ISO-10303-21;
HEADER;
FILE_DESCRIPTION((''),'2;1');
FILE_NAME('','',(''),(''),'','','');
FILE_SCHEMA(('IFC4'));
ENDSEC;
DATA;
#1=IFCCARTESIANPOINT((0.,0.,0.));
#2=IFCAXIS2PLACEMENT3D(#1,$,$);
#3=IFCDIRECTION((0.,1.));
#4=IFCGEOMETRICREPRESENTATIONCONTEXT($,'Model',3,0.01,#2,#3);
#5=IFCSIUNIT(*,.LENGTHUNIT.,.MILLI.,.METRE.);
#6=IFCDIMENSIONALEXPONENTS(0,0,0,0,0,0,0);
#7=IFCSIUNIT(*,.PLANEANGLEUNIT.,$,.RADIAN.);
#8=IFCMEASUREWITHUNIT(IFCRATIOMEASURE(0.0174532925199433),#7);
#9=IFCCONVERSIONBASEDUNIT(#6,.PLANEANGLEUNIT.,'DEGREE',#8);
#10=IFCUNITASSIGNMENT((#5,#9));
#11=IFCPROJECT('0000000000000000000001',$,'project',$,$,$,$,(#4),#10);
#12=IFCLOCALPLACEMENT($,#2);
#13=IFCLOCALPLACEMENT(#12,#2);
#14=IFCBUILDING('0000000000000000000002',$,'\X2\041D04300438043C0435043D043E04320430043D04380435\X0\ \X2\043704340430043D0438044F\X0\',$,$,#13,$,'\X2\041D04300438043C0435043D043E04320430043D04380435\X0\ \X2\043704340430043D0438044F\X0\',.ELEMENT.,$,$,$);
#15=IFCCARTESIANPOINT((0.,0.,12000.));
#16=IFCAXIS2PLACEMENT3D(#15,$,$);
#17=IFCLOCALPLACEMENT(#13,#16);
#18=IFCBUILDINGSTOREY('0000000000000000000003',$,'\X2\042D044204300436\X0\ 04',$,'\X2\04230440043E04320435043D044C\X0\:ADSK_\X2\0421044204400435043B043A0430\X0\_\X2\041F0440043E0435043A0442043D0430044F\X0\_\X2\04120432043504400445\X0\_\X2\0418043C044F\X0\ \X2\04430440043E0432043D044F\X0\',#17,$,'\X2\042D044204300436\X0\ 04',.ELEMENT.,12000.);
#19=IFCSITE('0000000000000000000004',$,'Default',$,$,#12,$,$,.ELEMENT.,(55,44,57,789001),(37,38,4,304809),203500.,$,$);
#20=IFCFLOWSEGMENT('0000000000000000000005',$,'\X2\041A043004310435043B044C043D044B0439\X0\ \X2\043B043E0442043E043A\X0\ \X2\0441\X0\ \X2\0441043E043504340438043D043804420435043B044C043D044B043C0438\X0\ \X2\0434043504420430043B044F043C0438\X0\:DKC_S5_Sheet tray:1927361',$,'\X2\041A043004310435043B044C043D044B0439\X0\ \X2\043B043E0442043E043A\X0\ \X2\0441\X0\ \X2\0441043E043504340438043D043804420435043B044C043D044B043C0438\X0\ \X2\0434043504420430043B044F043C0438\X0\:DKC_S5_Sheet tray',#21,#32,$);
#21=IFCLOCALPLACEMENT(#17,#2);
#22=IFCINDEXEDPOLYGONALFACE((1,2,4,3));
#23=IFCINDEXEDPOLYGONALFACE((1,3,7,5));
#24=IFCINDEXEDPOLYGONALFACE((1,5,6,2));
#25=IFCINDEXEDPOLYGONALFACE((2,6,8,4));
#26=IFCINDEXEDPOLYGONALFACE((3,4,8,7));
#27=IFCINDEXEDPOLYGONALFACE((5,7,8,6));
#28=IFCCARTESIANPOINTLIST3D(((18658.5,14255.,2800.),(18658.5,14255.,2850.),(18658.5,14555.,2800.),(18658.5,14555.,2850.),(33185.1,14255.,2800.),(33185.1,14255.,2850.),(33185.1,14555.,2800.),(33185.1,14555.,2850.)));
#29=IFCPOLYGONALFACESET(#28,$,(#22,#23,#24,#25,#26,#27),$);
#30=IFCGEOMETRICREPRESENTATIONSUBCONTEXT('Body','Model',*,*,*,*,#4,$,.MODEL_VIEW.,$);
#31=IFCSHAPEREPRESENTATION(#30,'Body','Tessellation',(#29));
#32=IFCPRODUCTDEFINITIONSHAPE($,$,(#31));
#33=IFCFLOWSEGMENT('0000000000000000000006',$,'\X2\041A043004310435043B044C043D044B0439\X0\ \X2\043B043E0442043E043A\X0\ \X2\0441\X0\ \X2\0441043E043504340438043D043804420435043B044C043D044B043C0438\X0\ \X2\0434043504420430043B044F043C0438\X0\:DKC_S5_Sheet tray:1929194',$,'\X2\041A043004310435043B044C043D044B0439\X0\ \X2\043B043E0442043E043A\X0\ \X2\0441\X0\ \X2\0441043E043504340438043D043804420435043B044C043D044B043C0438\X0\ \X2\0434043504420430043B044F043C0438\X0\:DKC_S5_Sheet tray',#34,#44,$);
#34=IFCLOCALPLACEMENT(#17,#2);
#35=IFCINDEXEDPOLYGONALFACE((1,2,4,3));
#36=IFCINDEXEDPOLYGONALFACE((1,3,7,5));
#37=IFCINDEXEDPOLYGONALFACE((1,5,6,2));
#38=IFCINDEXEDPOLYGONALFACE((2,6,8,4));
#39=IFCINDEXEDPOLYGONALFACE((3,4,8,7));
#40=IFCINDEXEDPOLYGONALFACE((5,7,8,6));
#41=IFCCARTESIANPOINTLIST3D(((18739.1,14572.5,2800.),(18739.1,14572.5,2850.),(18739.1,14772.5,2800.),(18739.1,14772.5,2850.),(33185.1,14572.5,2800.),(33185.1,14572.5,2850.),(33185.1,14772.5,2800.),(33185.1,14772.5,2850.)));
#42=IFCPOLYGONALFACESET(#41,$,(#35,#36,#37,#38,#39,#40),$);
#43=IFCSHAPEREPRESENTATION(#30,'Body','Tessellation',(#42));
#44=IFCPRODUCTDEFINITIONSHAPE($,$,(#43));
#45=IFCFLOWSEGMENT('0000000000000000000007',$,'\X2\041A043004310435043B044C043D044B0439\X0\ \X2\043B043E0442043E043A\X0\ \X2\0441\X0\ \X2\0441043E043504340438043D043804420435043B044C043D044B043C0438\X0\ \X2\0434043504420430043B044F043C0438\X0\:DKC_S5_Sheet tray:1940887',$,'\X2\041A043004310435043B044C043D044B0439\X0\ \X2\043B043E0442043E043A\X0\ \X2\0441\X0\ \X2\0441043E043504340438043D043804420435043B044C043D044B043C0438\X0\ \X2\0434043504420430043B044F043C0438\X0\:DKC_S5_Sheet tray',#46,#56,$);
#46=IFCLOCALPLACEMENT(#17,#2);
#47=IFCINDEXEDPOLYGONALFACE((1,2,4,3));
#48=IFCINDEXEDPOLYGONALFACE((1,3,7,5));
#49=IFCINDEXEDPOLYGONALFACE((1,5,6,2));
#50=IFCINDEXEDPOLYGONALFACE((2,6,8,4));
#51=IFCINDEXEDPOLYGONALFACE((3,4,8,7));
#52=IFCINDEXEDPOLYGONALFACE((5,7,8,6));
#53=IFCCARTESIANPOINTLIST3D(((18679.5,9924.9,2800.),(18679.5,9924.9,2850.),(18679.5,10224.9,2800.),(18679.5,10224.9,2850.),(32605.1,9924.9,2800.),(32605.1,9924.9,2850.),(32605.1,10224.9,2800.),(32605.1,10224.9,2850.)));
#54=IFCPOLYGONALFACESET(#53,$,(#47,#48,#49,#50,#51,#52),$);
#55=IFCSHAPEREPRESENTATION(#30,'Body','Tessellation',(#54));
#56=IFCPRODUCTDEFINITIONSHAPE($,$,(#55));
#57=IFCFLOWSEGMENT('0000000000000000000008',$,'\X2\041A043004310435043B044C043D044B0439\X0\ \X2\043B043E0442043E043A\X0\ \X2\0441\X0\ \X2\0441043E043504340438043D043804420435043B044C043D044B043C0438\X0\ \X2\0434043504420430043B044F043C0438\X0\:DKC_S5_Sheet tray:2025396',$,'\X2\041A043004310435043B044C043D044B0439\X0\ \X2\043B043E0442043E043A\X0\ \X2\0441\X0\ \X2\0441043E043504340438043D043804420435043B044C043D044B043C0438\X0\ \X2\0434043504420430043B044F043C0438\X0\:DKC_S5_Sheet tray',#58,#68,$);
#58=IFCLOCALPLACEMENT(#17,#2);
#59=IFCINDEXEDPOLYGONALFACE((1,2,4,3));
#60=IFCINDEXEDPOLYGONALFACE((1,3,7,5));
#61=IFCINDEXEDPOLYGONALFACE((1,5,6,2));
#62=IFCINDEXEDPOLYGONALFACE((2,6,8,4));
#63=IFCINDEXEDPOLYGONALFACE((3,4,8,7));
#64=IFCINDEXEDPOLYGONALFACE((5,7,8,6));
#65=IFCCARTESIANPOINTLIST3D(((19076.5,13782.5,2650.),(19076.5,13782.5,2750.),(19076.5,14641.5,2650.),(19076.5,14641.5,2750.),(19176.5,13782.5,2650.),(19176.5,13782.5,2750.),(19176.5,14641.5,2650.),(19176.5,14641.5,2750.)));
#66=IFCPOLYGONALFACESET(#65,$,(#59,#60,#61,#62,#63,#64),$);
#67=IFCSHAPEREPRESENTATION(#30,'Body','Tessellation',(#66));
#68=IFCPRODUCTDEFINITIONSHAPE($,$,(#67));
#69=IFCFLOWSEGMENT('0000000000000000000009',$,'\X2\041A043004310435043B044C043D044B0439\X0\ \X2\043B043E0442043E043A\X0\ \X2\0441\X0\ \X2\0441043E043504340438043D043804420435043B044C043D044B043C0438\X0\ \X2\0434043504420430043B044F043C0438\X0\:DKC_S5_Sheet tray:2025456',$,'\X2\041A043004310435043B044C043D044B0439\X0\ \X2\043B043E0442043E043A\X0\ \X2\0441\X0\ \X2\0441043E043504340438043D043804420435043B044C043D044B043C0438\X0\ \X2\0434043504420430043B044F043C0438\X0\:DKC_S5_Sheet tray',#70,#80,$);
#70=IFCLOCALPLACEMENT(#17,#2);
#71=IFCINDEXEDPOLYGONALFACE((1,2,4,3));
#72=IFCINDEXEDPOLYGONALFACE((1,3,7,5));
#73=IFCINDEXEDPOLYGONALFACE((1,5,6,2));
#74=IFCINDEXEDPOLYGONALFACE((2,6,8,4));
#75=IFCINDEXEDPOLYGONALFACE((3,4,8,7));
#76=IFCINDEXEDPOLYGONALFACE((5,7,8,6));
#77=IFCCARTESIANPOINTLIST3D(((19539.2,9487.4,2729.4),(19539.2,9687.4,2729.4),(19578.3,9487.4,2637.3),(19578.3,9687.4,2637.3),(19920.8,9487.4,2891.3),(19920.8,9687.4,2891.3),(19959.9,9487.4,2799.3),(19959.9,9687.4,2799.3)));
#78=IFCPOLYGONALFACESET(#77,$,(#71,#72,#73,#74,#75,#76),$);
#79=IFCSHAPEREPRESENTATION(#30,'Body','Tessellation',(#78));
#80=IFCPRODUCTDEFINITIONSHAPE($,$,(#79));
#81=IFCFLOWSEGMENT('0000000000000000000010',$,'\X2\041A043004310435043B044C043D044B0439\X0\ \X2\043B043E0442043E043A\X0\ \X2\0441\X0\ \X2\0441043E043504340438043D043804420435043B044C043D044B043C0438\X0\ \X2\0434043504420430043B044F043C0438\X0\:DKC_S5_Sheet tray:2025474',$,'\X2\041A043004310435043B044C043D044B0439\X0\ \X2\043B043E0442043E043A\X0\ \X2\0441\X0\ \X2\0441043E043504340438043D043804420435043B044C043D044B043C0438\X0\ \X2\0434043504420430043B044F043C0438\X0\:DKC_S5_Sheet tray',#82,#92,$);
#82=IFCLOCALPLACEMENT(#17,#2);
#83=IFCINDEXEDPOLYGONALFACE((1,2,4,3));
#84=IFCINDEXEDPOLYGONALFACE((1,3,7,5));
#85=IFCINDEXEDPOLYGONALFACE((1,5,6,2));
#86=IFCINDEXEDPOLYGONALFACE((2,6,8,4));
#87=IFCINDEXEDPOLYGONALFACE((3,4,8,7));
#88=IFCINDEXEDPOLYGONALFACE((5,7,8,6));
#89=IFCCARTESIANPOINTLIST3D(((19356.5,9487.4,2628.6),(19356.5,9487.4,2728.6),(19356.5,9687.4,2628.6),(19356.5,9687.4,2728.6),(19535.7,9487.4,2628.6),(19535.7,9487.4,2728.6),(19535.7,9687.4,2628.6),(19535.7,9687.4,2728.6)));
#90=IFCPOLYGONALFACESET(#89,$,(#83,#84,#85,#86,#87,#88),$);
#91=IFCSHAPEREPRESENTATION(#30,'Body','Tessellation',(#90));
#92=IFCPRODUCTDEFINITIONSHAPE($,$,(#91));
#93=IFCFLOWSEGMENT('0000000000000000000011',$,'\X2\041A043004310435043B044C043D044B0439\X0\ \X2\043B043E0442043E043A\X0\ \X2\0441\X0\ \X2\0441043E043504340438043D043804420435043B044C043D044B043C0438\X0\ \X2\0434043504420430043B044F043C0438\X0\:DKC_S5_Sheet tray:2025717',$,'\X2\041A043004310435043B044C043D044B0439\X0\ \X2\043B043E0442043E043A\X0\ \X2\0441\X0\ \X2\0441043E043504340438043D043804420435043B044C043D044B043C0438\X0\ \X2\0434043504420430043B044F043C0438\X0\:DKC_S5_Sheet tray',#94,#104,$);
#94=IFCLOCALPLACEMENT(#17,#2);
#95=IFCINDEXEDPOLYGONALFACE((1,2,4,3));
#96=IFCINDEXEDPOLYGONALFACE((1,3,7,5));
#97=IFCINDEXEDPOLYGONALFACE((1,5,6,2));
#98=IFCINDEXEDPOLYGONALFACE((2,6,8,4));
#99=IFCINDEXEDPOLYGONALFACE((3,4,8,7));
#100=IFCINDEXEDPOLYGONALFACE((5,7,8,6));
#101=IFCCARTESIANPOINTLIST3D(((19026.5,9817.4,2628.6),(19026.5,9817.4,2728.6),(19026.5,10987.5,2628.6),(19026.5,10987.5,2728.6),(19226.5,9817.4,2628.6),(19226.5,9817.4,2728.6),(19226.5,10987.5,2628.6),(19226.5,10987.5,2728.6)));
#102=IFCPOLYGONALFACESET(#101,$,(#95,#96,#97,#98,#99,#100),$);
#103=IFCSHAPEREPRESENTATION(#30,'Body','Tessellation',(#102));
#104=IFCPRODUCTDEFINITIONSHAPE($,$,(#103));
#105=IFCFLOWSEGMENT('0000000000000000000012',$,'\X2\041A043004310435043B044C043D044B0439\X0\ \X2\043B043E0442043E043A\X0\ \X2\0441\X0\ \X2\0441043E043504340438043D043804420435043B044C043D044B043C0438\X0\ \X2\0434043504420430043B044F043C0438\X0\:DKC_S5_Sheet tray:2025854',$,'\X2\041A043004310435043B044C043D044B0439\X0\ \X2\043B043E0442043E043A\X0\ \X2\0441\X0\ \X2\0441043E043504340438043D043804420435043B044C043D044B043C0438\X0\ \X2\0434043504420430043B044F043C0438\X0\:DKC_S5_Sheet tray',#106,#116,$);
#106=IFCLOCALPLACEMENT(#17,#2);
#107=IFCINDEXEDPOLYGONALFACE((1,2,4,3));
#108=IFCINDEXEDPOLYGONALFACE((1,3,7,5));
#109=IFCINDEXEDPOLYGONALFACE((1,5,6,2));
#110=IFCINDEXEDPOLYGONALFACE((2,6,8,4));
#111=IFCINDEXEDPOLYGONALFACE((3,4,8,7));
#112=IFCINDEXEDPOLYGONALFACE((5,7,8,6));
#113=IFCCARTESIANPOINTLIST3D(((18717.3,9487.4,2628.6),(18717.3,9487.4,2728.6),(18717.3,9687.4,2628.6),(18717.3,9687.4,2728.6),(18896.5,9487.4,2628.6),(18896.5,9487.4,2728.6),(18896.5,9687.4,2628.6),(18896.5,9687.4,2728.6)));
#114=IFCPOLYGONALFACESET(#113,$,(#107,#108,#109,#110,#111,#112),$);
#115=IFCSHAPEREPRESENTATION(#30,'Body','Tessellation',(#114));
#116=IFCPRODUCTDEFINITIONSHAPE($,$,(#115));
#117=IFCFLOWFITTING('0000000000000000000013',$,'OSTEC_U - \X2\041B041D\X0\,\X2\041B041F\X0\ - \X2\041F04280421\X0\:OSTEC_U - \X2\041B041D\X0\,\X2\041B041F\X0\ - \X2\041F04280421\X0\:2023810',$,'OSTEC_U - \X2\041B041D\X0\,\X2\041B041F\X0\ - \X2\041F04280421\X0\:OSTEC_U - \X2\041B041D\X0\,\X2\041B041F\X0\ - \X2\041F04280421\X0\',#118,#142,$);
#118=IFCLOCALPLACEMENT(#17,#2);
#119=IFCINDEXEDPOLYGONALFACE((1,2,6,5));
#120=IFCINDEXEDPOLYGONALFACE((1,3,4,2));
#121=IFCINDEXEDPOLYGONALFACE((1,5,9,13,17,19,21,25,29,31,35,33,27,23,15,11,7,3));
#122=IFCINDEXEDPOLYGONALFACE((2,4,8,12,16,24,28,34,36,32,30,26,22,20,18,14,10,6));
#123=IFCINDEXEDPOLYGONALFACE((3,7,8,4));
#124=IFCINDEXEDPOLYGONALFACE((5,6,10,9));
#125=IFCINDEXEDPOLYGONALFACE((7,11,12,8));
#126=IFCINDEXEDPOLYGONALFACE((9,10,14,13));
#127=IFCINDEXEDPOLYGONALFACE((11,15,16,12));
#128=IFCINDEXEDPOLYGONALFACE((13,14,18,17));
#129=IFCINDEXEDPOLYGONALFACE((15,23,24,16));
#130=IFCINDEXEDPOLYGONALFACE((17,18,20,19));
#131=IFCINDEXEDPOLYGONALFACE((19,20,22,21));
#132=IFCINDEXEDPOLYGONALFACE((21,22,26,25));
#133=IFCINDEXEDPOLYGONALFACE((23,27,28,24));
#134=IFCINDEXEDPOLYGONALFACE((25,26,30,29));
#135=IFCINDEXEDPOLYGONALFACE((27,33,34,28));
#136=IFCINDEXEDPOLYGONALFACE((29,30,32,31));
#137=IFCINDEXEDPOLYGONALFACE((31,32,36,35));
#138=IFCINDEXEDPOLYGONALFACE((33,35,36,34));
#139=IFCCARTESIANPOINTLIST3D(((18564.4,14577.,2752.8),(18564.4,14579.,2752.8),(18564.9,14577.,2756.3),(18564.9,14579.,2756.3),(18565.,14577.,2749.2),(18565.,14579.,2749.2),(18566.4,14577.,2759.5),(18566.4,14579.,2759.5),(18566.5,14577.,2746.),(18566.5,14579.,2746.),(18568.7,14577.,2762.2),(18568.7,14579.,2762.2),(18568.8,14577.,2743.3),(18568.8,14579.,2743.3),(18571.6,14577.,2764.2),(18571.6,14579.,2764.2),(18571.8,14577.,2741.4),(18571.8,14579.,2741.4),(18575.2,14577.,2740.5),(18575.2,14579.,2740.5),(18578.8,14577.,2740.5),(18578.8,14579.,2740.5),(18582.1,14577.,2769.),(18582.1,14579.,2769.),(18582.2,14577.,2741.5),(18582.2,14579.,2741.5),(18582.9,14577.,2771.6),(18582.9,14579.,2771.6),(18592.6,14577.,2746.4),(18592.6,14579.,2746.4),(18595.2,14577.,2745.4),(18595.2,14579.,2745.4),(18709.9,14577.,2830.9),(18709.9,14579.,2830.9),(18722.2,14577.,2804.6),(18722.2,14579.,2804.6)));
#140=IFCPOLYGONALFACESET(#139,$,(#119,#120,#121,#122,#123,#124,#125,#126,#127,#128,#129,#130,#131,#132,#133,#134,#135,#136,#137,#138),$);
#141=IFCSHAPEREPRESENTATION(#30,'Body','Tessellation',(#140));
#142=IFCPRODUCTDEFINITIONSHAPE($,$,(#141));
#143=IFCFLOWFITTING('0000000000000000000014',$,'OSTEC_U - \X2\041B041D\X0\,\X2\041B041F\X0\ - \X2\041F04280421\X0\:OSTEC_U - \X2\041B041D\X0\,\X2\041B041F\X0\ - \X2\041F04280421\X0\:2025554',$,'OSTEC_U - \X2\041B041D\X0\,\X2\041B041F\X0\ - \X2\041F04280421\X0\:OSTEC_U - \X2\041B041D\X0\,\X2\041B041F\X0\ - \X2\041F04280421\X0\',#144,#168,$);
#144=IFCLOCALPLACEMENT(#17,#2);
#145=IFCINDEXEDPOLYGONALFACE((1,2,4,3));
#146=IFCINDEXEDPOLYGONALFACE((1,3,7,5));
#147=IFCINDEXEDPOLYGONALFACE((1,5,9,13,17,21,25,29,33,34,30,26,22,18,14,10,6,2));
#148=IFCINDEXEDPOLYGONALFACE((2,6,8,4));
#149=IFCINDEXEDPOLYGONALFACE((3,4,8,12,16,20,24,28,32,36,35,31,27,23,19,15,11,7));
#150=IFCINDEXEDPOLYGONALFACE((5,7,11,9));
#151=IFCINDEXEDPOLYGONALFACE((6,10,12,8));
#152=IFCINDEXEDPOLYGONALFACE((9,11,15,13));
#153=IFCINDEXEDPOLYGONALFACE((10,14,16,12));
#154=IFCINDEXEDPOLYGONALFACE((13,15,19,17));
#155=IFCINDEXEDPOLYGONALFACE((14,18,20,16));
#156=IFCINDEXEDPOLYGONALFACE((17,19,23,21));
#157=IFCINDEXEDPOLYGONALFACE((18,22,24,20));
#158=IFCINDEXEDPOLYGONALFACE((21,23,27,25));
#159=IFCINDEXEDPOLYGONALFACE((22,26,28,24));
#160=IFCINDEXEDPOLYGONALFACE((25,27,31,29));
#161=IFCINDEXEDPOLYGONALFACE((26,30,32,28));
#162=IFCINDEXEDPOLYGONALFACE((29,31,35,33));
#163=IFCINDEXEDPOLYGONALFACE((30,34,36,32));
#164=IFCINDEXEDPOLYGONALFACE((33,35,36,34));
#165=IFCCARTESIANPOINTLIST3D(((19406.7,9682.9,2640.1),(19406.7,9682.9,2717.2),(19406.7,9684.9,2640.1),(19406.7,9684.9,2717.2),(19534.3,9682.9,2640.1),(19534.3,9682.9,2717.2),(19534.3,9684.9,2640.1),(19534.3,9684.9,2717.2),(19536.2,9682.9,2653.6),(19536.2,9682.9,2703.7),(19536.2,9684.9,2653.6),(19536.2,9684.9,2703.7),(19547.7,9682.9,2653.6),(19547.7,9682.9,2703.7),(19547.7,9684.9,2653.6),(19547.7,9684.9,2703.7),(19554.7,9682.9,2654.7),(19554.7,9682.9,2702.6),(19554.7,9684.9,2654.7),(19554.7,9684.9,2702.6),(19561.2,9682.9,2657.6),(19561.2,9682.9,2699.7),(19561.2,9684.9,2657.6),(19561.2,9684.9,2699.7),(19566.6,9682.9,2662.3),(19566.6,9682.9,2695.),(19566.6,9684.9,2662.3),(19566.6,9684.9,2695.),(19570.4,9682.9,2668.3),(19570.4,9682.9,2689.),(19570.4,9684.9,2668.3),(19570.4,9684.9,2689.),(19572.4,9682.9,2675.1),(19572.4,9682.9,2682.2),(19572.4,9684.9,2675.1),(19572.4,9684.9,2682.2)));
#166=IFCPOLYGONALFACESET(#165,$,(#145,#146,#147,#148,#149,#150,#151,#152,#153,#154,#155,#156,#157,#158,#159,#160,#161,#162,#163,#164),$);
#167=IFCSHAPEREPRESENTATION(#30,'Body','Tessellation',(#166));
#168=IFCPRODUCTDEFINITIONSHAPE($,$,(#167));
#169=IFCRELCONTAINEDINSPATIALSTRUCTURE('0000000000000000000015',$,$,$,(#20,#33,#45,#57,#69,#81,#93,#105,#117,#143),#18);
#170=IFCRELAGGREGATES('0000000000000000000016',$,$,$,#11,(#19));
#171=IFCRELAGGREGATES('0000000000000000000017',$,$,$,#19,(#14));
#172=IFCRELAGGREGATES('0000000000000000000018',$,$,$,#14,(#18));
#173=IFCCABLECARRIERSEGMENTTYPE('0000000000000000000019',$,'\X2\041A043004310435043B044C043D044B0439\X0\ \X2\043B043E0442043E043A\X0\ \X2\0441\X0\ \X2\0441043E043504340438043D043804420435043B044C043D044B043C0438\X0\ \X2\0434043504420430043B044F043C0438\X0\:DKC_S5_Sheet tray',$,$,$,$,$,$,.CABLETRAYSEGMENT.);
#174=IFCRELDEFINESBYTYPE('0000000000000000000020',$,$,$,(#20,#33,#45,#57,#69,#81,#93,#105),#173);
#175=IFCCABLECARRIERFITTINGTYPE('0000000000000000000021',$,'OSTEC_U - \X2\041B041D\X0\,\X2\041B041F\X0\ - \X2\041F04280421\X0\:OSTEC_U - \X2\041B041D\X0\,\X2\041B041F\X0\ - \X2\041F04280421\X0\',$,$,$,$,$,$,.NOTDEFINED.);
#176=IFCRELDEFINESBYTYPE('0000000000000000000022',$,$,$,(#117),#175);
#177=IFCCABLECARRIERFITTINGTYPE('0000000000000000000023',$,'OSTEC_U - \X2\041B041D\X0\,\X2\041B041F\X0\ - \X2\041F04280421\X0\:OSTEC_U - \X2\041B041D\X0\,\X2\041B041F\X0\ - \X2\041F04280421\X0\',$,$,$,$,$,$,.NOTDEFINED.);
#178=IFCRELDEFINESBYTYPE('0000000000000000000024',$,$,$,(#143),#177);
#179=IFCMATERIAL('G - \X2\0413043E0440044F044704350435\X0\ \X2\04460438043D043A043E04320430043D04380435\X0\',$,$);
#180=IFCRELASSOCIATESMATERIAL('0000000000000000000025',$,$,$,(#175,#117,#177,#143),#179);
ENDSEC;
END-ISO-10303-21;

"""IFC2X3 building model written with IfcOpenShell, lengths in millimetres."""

from ifc_helpers import new_model, entity, si_unit, converted_unit, direction, frame, frame_2d, origin, origin_2d_with_axis, place, context, subcontext, project, spatial, polyline, circle_curve, parameter, trimmed, segment, composite_curve, rectangle, outline, extrude, source, transform, mapped, material, type_object, type_shapes, element, save


model = new_model("IFC2X3")

# Units and contexts
model_context = context("Model", 3, precision=0.01, world=origin(), true_north=direction((0.0, 1.0)))
body_context = subcontext(model_context, "Body", "Model", "MODEL_VIEW")
ifc_project = project(units=[si_unit("LENGTHUNIT", "METRE", prefix="MILLI"), converted_unit("PLANEANGLEUNIT", "DEGREE", entity("IfcRatioMeasure", 0.0174532925199433), si_unit("PLANEANGLEUNIT", "RADIAN"), dimensions=[0, 0, 0, 0, 0, 0, 0])], contexts=[model_context])

# Site, building, storey
site_placement = place(None, origin())
site = spatial("IfcSite", under=ifc_project, at=site_placement, Name="Default", CompositionType="ELEMENT", RefLatitude=(55, 44, 57, 789001), RefLongitude=(37, 38, 4, 304809), RefElevation=203500.0)
building_placement = place(site_placement, origin())
building = spatial("IfcBuilding", under=site, at=building_placement, Name="Наименование здания", LongName="Наименование здания", CompositionType="ELEMENT")
storey_placement = place(building_placement, frame((0.0, 0.0, 12000.0)))
storey = spatial("IfcBuildingStorey", under=building, at=storey_placement, Name="Этаж 04", ObjectType="Уровень:ADSK_Стрелка_Проектная_Вверх_Имя уровня", LongName="Этаж 04", CompositionType="ELEMENT", Elevation=12000.0)

# Flow segments
cable_carrier_segment_type = type_object("IfcCableCarrierSegmentType", Name="Кабельный лоток с соединительными деталями:DKC_S5_Sheet tray", PredefinedType="CABLETRAYSEGMENT")
flow_segment_1_placement = place(storey_placement, frame((18658.5, 14255.0, 2800.0)))
element("IfcFlowSegment", 1, at=flow_segment_1_placement, inside=storey, type_object=cable_carrier_segment_type, Name="Кабельный лоток с соединительными деталями:DKC_S5_Sheet tray:1927361", ObjectType="Кабельный лоток с соединительными деталями:DKC_S5_Sheet tray", context=body_context, shape_type="SweptSolid", body=[
    extrude(rectangle(XDim=14526.6, YDim=300.0, at=origin_2d_with_axis()), frame((7263.3, 150.0, 0.0)), (0.0, 0.0, 1.0), 50.0),
])
flow_segment_2_placement = place(storey_placement, frame((18739.1, 14572.5, 2800.0)))
element("IfcFlowSegment", 2, at=flow_segment_2_placement, inside=storey, type_object=cable_carrier_segment_type, Name="Кабельный лоток с соединительными деталями:DKC_S5_Sheet tray:1929194", ObjectType="Кабельный лоток с соединительными деталями:DKC_S5_Sheet tray", context=body_context, shape_type="SweptSolid", body=[
    extrude(rectangle(XDim=14446.0, YDim=200.0, at=origin_2d_with_axis()), frame((7223.0, 100.0, 0.0)), (0.0, 0.0, 1.0), 50.0),
])
flow_segment_3_placement = place(storey_placement, frame((18679.5, 9924.9, 2800.0)))
element("IfcFlowSegment", 3, at=flow_segment_3_placement, inside=storey, type_object=cable_carrier_segment_type, Name="Кабельный лоток с соединительными деталями:DKC_S5_Sheet tray:1940887", ObjectType="Кабельный лоток с соединительными деталями:DKC_S5_Sheet tray", context=body_context, shape_type="SweptSolid", body=[
    extrude(rectangle(XDim=13925.6, YDim=300.0, at=origin_2d_with_axis()), frame((6962.8, 150.0, 0.0)), (0.0, 0.0, 1.0), 50.0),
])
flow_segment_4_placement = place(storey_placement, frame((19076.5, 13782.5, 2650.0)))
element("IfcFlowSegment", 4, at=flow_segment_4_placement, inside=storey, type_object=cable_carrier_segment_type, Name="Кабельный лоток с соединительными деталями:DKC_S5_Sheet tray:2025396", ObjectType="Кабельный лоток с соединительными деталями:DKC_S5_Sheet tray", context=body_context, shape_type="SweptSolid", body=[
    extrude(rectangle(XDim=859.0, YDim=100.0, at=origin_2d_with_axis()), frame((50.0, 429.5, 0.0), z_axis=(0.0, 0.0, 1.0), x_axis=(0.0, -1.0, 0.0)), (0.0, 0.0, 1.0), 100.0),
])
flow_segment_5_placement = place(storey_placement, frame((19539.2, 9487.5, 2637.3)))
element("IfcFlowSegment", 5, at=flow_segment_5_placement, inside=storey, type_object=cable_carrier_segment_type, Name="Кабельный лоток с соединительными деталями:DKC_S5_Sheet tray:2025456", ObjectType="Кабельный лоток с соединительными деталями:DKC_S5_Sheet tray", context=body_context, shape_type="SweptSolid", body=[
    extrude(rectangle(XDim=100.0, YDim=200.0, at=origin_2d_with_axis()), frame((19.5, 100.0, 46.0), z_axis=(0.920505, 0.0, 0.390731), x_axis=(-0.390731, 0.0, 0.920505)), (0.0, 0.0, 1.0), 414.6),
])
flow_segment_6_placement = place(storey_placement, frame((19356.5, 9487.5, 2628.7)))
element("IfcFlowSegment", 6, at=flow_segment_6_placement, inside=storey, type_object=cable_carrier_segment_type, Name="Кабельный лоток с соединительными деталями:DKC_S5_Sheet tray:2025474", ObjectType="Кабельный лоток с соединительными деталями:DKC_S5_Sheet tray", context=body_context, shape_type="SweptSolid", body=[
    extrude(rectangle(XDim=179.2, YDim=200.0, at=origin_2d_with_axis()), frame((89.6, 100.0, 0.0), z_axis=(0.0, 0.0, 1.0), x_axis=(-1.0, 0.0, 0.0)), (0.0, 0.0, 1.0), 100.0),
])
flow_segment_7_placement = place(storey_placement, frame((19026.5, 9817.5, 2628.7)))
element("IfcFlowSegment", 7, at=flow_segment_7_placement, inside=storey, type_object=cable_carrier_segment_type, Name="Кабельный лоток с соединительными деталями:DKC_S5_Sheet tray:2025717", ObjectType="Кабельный лоток с соединительными деталями:DKC_S5_Sheet tray", context=body_context, shape_type="SweptSolid", body=[
    extrude(rectangle(XDim=1170.0, YDim=200.0, at=origin_2d_with_axis()), frame((100.0, 585.0, 0.0), z_axis=(0.0, 0.0, 1.0), x_axis=(0.0, 1.0, 0.0)), (0.0, 0.0, 1.0), 100.0),
])
flow_segment_8_placement = place(storey_placement, frame((18717.3, 9487.5, 2628.7)))
element("IfcFlowSegment", 8, at=flow_segment_8_placement, inside=storey, type_object=cable_carrier_segment_type, Name="Кабельный лоток с соединительными деталями:DKC_S5_Sheet tray:2025854", ObjectType="Кабельный лоток с соединительными деталями:DKC_S5_Sheet tray", context=body_context, shape_type="SweptSolid", body=[
    extrude(rectangle(XDim=179.2, YDim=200.0, at=origin_2d_with_axis()), frame((89.6, 100.0, 0.0)), (0.0, 0.0, 1.0), 100.0),
])

# Flow fittings
ifc_material = material(Name="G - Горячее цинкование")
shared_shape_1 = source(origin(), body_context, "Body", "SweptSolid", [
    extrude(outline(composite_curve([segment(trimmed(circle_curve(frame_2d((-44.6, 0.0), x_axis=(1.0, 0.0)), 12.5), [parameter(90.0)], [parameter(270.0)], True, "PARAMETER"), True, "CONTINUOUS"), segment(polyline([(-44.6, -12.5), (-33.1, -12.5)]), True, "CONTINUOUS"), segment(polyline([(-33.1, -12.5), (-31.2, -14.5)]), True, "CONTINUOUS"), segment(polyline([(-31.2, -14.5), (108.9, -14.5)]), True, "CONTINUOUS"), segment(polyline([(108.9, -14.5), (108.9, 14.5)]), True, "CONTINUOUS"), segment(polyline([(108.9, 14.5), (-31.2, 14.5)]), True, "CONTINUOUS"), segment(polyline([(-31.2, 14.5), (-33.1, 12.5)]), True, "CONTINUOUS"), segment(polyline([(-33.1, 12.5), (-44.6, 12.5)]), True, "CONTINUOUS")], self_intersect=False)), frame((44.6, 0.0, 0.0), z_axis=(0.0, 0.0, -1.0), x_axis=(1.0, 0.0, 0.0)), (0.0, 0.0, -1.0), 2.0),
])
cable_carrier_fitting_type_1 = type_object("IfcCableCarrierFittingType", Name="OSTEC_U - ЛН,ЛП - ПШС:OSTEC_U - ЛН,ЛП - ПШС", PredefinedType="NOTDEFINED", material=ifc_material)
type_shapes(cable_carrier_fitting_type_1, [shared_shape_1])
flow_fitting_1_placement = place(storey_placement, frame((18576.9, 14579.0, 2752.8), z_axis=(0.0, -1.0, 0.0), x_axis=(0.906308, 0.0, 0.422618)))
element("IfcFlowFitting", 9, at=flow_fitting_1_placement, inside=storey, type_object=cable_carrier_fitting_type_1, material=ifc_material, Name="OSTEC_U - ЛН,ЛП - ПШС:OSTEC_U - ЛН,ЛП - ПШС:2023810", ObjectType="OSTEC_U - ЛН,ЛП - ПШС:OSTEC_U - ЛН,ЛП - ПШС", context=body_context, shape_type="MappedRepresentation", body=[
    mapped(shared_shape_1, transform((0.0, 0.0, 0.0), scale=1.0)),
])
cable_carrier_fitting_type_2 = type_object("IfcCableCarrierFittingType", Name="OSTEC_U - ЛН,ЛП - ПШС:OSTEC_U - ЛН,ЛП - ПШС", PredefinedType="NOTDEFINED", material=ifc_material)
shared_shape_2 = source(origin(), body_context, "Body", "SweptSolid", [
    extrude(outline(composite_curve([segment(trimmed(circle_curve(frame_2d((-41.5, 0.0), x_axis=(1.0, 0.0)), 25.0), [parameter(90.0)], [parameter(270.0)], True, "PARAMETER"), True, "CONTINUOUS"), segment(polyline([(-41.5, -25.0), (-30.0, -25.0)]), True, "CONTINUOUS"), segment(polyline([(-30.0, -25.0), (-28.1, -38.5)]), True, "CONTINUOUS"), segment(polyline([(-28.1, -38.5), (99.5, -38.5)]), True, "CONTINUOUS"), segment(polyline([(99.5, -38.5), (99.5, 38.5)]), True, "CONTINUOUS"), segment(polyline([(99.5, 38.5), (-28.1, 38.5)]), True, "CONTINUOUS"), segment(polyline([(-28.1, 38.5), (-30.0, 25.0)]), True, "CONTINUOUS"), segment(polyline([(-30.0, 25.0), (-41.5, 25.0)]), True, "CONTINUOUS")], self_intersect=False)), frame((41.5, 0.0, 0.0), z_axis=(0.0, 0.0, -1.0), x_axis=(1.0, 0.0, 0.0)), (0.0, 0.0, -1.0), 2.0),
])
type_shapes(cable_carrier_fitting_type_2, [shared_shape_2])
flow_fitting_2_placement = place(storey_placement, frame((19547.7, 9682.9, 2678.7), z_axis=(0.0, 1.0, 0.0), x_axis=(-1.0, 0.0, 0.0)))
element("IfcFlowFitting", 10, at=flow_fitting_2_placement, inside=storey, type_object=cable_carrier_fitting_type_2, material=ifc_material, Name="OSTEC_U - ЛН,ЛП - ПШС:OSTEC_U - ЛН,ЛП - ПШС:2025554", ObjectType="OSTEC_U - ЛН,ЛП - ПШС:OSTEC_U - ЛН,ЛП - ПШС", context=body_context, shape_type="MappedRepresentation", body=[
    mapped(shared_shape_2, transform((0.0, 0.0, 0.0), scale=1.0)),
])

save(model, "model.ifc")
